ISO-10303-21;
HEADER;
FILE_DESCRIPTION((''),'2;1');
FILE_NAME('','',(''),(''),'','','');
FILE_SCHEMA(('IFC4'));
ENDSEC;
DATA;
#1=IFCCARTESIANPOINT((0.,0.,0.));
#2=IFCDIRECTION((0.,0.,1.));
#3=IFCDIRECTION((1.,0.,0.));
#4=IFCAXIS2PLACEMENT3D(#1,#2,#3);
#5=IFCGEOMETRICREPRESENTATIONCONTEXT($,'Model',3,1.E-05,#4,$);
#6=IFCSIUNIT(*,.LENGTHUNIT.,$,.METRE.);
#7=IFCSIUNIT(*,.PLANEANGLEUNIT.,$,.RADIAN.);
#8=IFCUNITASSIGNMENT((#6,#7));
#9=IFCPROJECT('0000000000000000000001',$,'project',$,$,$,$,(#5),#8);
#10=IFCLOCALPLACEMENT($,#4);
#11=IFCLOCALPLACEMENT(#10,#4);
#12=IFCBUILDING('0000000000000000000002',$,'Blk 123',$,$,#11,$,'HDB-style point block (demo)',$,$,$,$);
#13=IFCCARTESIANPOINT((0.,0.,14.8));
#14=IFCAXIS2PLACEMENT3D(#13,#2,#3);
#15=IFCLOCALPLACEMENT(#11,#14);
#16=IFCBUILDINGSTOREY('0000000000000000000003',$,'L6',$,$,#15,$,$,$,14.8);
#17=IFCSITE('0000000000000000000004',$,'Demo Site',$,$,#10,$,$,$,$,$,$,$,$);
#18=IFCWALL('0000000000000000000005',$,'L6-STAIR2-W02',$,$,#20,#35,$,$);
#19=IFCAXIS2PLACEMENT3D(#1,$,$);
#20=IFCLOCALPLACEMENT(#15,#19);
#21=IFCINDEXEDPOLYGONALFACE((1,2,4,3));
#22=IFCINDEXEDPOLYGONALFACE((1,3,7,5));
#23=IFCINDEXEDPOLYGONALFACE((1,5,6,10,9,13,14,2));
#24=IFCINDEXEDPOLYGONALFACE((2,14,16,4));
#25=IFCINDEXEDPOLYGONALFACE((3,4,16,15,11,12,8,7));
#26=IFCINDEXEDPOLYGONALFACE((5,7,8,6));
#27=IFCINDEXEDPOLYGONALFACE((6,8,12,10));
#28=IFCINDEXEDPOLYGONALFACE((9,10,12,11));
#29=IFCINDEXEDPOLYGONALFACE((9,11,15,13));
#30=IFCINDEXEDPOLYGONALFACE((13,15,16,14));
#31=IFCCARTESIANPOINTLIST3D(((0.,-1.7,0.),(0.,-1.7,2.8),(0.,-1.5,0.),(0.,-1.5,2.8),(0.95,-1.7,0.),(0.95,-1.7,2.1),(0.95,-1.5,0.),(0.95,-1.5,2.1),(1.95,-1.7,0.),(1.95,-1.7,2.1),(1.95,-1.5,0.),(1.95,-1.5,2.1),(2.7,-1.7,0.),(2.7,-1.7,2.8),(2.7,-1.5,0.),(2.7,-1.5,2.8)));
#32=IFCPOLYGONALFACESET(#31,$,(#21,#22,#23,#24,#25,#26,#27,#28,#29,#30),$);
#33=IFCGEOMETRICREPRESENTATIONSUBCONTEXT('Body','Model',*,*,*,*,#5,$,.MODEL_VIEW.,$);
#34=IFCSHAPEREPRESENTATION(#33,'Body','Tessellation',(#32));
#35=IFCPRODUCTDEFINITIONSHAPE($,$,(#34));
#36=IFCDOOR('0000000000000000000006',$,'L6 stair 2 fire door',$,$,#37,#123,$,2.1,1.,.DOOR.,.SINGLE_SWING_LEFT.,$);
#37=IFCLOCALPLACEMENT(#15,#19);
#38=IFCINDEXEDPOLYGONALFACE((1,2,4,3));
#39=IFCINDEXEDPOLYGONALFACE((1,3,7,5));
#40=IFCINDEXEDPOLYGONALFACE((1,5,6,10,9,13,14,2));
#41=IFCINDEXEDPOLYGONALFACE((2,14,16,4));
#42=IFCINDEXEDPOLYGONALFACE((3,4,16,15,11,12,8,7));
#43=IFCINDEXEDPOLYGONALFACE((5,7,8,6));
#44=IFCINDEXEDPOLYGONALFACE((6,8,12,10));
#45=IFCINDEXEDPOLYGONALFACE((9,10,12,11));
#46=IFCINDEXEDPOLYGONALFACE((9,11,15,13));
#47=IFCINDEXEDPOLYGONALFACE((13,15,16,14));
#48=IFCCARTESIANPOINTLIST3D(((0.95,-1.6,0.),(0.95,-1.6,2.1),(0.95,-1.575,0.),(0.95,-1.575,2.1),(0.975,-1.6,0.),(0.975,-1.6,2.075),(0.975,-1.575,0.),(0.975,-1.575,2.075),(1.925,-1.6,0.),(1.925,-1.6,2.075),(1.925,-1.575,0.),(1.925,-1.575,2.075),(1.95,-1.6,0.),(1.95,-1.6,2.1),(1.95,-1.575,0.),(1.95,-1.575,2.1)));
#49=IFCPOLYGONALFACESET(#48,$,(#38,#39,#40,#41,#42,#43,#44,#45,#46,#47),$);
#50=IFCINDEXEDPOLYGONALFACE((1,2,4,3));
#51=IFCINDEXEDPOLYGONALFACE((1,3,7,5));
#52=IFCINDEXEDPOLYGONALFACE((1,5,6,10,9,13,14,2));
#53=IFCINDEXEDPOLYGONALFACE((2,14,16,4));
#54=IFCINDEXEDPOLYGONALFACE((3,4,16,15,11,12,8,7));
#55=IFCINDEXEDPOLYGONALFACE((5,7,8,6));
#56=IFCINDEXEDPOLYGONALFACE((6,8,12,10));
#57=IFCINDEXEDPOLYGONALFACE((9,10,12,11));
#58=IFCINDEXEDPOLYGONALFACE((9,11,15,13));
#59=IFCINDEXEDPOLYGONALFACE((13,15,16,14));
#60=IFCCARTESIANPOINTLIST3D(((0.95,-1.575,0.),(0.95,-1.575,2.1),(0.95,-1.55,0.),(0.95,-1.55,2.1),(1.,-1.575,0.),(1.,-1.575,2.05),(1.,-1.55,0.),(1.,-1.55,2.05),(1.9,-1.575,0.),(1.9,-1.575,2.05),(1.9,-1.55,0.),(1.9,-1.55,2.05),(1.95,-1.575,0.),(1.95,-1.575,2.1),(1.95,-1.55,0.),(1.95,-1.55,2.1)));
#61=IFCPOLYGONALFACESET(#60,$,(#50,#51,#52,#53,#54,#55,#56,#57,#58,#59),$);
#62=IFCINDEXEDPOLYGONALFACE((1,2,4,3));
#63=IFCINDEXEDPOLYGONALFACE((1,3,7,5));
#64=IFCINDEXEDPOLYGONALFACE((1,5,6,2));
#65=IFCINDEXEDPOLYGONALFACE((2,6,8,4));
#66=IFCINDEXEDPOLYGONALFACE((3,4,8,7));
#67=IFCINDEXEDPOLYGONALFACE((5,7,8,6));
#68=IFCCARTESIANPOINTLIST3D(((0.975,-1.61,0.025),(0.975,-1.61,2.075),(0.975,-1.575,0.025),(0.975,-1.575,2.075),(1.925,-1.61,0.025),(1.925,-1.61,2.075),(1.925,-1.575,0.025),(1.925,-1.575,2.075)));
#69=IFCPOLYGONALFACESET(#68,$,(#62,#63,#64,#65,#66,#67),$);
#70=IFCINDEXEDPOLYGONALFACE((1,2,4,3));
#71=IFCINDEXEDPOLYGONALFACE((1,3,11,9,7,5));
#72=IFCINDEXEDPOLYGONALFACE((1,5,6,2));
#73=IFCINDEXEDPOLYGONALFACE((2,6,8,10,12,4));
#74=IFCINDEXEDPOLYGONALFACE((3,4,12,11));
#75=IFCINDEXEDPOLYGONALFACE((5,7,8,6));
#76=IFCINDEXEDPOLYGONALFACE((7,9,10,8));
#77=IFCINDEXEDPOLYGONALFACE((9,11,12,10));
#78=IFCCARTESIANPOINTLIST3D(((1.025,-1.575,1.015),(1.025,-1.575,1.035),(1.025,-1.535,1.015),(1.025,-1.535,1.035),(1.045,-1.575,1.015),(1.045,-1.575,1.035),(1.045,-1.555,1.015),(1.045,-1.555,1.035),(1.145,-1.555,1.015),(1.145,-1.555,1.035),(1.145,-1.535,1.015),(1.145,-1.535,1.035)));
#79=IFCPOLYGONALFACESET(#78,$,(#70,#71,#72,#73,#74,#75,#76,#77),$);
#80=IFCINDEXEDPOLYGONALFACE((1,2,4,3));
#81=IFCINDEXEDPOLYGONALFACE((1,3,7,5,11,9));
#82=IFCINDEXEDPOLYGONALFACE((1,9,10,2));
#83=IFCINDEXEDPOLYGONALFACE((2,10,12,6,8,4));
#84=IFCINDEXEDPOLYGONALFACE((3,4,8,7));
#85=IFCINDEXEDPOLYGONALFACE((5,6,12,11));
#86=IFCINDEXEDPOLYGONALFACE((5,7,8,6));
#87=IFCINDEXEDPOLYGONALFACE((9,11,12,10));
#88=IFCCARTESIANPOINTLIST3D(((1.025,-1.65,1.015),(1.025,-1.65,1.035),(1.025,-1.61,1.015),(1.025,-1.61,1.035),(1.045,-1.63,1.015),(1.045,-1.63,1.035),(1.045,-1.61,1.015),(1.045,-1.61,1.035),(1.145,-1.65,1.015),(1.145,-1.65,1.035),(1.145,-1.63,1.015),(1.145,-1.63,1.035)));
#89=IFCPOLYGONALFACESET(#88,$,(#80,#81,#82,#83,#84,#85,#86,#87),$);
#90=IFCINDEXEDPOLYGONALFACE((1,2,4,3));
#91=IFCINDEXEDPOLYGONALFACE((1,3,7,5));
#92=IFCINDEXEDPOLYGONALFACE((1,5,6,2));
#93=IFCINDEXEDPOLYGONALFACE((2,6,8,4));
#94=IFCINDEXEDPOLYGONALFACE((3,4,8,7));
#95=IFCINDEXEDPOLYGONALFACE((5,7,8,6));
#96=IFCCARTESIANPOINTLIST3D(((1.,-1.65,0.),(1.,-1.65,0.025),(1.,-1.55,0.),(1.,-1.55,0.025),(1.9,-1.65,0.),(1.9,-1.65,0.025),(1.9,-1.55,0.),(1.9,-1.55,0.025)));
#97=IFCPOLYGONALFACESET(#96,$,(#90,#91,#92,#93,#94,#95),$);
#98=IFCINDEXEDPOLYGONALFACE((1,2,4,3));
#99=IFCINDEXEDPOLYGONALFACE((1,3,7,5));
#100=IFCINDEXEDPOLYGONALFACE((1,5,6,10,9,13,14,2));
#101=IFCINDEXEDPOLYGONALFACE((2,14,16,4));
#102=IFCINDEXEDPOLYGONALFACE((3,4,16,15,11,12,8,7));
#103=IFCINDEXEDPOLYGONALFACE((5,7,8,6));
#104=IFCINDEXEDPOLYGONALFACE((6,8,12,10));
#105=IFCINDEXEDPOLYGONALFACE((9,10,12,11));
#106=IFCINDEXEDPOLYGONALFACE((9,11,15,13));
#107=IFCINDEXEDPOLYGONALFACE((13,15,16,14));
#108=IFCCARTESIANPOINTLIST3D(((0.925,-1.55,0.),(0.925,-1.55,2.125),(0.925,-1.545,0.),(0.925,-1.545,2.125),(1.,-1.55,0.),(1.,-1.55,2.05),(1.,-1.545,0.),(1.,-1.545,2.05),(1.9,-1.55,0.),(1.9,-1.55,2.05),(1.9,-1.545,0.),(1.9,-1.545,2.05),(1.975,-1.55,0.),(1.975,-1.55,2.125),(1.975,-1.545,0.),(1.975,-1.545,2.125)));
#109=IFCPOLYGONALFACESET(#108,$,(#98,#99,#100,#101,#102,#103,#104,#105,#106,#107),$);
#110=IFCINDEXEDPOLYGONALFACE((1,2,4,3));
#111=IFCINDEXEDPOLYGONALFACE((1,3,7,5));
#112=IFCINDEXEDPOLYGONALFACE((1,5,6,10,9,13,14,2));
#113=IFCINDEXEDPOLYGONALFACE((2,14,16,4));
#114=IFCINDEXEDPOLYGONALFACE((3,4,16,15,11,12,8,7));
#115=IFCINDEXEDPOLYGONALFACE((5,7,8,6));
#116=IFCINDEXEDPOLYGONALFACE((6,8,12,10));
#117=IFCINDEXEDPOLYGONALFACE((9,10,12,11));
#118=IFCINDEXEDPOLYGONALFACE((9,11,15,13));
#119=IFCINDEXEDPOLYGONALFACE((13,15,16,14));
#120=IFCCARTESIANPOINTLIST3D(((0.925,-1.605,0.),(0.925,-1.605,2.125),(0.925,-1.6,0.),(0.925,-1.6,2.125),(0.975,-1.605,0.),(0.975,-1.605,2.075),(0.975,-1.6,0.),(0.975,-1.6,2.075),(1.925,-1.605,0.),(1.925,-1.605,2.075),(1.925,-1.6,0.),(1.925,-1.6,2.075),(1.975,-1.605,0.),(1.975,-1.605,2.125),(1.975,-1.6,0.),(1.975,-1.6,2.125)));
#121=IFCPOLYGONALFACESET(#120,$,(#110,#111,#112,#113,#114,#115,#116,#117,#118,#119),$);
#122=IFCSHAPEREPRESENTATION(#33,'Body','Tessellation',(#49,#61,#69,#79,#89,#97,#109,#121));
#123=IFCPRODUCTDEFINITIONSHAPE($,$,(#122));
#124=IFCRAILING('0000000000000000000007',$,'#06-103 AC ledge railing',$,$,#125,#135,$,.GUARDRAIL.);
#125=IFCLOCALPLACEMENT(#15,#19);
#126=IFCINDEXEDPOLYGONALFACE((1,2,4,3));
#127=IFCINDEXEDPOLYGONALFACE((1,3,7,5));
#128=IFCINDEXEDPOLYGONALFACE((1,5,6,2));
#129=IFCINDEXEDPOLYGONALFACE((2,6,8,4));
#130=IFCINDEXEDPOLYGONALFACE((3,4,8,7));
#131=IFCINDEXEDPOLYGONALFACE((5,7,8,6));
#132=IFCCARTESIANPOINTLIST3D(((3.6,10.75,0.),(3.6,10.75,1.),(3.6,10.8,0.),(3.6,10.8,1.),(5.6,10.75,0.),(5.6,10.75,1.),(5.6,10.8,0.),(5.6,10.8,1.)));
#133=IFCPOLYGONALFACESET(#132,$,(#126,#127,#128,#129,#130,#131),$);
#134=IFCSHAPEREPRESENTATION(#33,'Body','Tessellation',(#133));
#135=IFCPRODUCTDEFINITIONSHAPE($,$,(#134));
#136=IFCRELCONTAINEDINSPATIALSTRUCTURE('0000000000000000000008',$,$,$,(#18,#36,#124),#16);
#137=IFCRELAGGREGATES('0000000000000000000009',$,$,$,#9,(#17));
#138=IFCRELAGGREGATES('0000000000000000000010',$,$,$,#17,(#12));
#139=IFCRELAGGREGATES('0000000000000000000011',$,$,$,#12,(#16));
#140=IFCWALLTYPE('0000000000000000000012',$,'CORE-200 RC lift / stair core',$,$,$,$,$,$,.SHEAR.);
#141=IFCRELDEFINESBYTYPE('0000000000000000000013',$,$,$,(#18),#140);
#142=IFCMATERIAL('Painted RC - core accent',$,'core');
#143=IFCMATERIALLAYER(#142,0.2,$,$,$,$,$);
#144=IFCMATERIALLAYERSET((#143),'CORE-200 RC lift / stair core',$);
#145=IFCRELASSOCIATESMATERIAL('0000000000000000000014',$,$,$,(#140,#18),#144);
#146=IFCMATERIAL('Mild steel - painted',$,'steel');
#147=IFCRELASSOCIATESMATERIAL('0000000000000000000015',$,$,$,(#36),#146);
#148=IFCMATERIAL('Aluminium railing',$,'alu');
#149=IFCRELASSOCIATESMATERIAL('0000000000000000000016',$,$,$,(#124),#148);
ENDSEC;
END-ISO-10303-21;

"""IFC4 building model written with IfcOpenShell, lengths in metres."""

from ifc_helpers import new_model, si_unit, frame, origin, origin_with_axes, place, context, subcontext, project, spatial, polyline, line, indexed_curve, outline, extrude, material, layer, layer_set, layer_usage, type_object, element, fill, save


model = new_model("IFC4")

# Units and contexts
model_context = context("Model", 3, precision=1e-05, world=origin_with_axes())
body_context = subcontext(model_context, "Body", "Model", "MODEL_VIEW")
ifc_project = project(units=[si_unit("LENGTHUNIT", "METRE"), si_unit("PLANEANGLEUNIT", "RADIAN")], contexts=[model_context])

# Site, building, storey
site_placement = place(None, origin_with_axes())
site = spatial("IfcSite", under=ifc_project, at=site_placement, Name="Demo Site")
building_placement = place(site_placement, origin_with_axes())
building = spatial("IfcBuilding", under=site, at=building_placement, Name="Blk 123", LongName="HDB-style point block (demo)")
storey_placement = place(building_placement, frame((0.0, 0.0, 14.8), z_axis=(0.0, 0.0, 1.0), x_axis=(1.0, 0.0, 0.0)))
storey = spatial("IfcBuildingStorey", under=building, at=storey_placement, Name="L6", Elevation=14.8)

# Shared definitions
ifc_material_1 = material(Name="Painted RC - core accent", Category="core")
ifc_layer_1 = layer(ifc_material_1, 0.2)
ifc_layer_set_1 = layer_set([ifc_layer_1], Name="CORE-200 RC lift / stair core")
ifc_layer_usage_1 = layer_usage(ifc_layer_set_1, "AXIS2", "POSITIVE", 0.0)
wall_type_1 = type_object("IfcWallType", Name="CORE-200 RC lift / stair core", PredefinedType="SHEAR", material=ifc_layer_set_1)

# Wall, opening, door
wall_1_placement = place(storey_placement, frame((2.7, -1.5, 0.0), z_axis=(0.0, 0.0, 1.0), x_axis=(-1.0, 0.0, 0.0)))
wall_1 = element("IfcWall", 1, at=wall_1_placement, inside=storey, type_object=wall_type_1, material=ifc_layer_usage_1, Name="L6-STAIR2-W02", context=body_context, shape_type="SweptSolid", body=[
    extrude(outline(indexed_curve([(0.0, 0.0), (0.0, 0.2), (2.7, 0.2), (2.7, 0.0), (0.0, 0.0)], self_intersect=False)), origin_with_axes(), (0.0, 0.0, 1.0), 2.8),
])
opening_1_placement = place(wall_1_placement, frame((0.75, -0.1, 0.0), z_axis=(0.0, 0.0, 1.0), x_axis=(1.0, 0.0, 0.0)))
opening_1 = element("IfcOpeningElement", 2, at=opening_1_placement, cuts=wall_1, context=body_context, shape_type="SweptSolid", body=[
    extrude(outline(indexed_curve([(0.0, 0.0), (0.0, 0.4), (1.0, 0.4), (1.0, 0.0), (0.0, 0.0)], self_intersect=False)), origin_with_axes(), (0.0, 0.0, 1.0), 2.1),
])
ifc_material_2 = material(Name="Mild steel - painted", Category="steel")
door_1_placement = place(opening_1_placement, frame((0.0, 0.15, 0.0), z_axis=(0.0, 0.0, 1.0), x_axis=(1.0, 0.0, 0.0)))
door_1 = element("IfcDoor", 3, at=door_1_placement, inside=storey, material=ifc_material_2, Name="L6 stair 2 fire door", OperationType="SINGLE_SWING_LEFT", OverallHeight=2.1, OverallWidth=1.0, PredefinedType="DOOR", context=body_context, shape_type="SweptSolid", body=[
    extrude(outline(indexed_curve([(0.0, 0.0), (0.0, 2.1), (1.0, 2.1), (1.0, 0.0), (0.975, 0.0), (0.975, 2.075), (0.025, 2.075), (0.025, 0.0)], segments=[line(1, 2, 3, 4, 5, 6, 7, 8, 1)])), frame((0.0, 0.025, 0.0), z_axis=(0.0, -1.0, 0.0), x_axis=(1.0, 0.0, 0.0)), (0.0, 0.0, -1.0), 0.025),
    extrude(outline(indexed_curve([(0.0, 0.0), (0.0, 2.1), (1.0, 2.1), (1.0, 0.0), (0.95, 0.0), (0.95, 2.05), (0.05, 2.05), (0.05, 0.0)], segments=[line(1, 2, 3, 4, 5, 6, 7, 8, 1)])), frame((0.0, 0.0, 0.0), z_axis=(0.0, -1.0, 0.0), x_axis=(1.0, 0.0, 0.0)), (0.0, 0.0, -1.0), 0.025),
    extrude(outline(indexed_curve([(0.0, 0.0), (0.95, 0.0), (0.95, 0.035), (0.0, 0.035)], segments=[line(1, 2, 3, 4, 1)])), frame((0.025, 0.025, 0.025), z_axis=(0.0, 0.0, 1.0), x_axis=(1.0, 0.0, 0.0)), (0.0, 0.0, 1.0), 2.05),
    extrude(outline(indexed_curve([(0.0, 0.0), (0.0, -0.04), (-0.12, -0.04), (-0.12, -0.02), (-0.02, -0.02), (-0.02, 0.0)], segments=[line(1, 2, 3, 4, 5, 6, 1)])), frame((0.925, 0.025, 1.015), z_axis=(0.0, 0.0, 1.0), x_axis=(1.0, 0.0, 0.0)), (0.0, 0.0, 1.0), 0.02),
    extrude(outline(indexed_curve([(0.0, 0.0), (0.0, 0.04), (-0.12, 0.04), (-0.12, 0.02), (-0.02, 0.02), (-0.02, 0.0)], segments=[line(1, 2, 3, 4, 5, 6, 1)])), frame((0.925, 0.06, 1.015), z_axis=(0.0, 0.0, 1.0), x_axis=(1.0, 0.0, 0.0)), (0.0, 0.0, 1.0), 0.02),
    extrude(outline(indexed_curve([(0.0, 0.0), (0.9, 0.0), (0.9, 0.1), (0.0, 0.1)], segments=[line(1, 2, 3, 4, 1)])), frame((0.05, 0.0, 0.0), z_axis=(0.0, 0.0, 1.0), x_axis=(1.0, 0.0, 0.0)), (0.0, 0.0, 1.0), 0.025),
    extrude(outline(indexed_curve([(0.0, 0.0), (0.0, 2.125), (1.05, 2.125), (1.05, 0.0), (0.975, 0.0), (0.975, 2.05), (0.075, 2.05), (0.075, 0.0)], segments=[line(1, 2, 3, 4, 5, 6, 7, 8, 1)])), frame((-0.025, -0.005, 0.0), z_axis=(0.0, -1.0, 0.0), x_axis=(1.0, 0.0, 0.0)), (0.0, 0.0, -1.0), 0.005),
    extrude(outline(indexed_curve([(0.0, 0.0), (0.0, 2.125), (1.05, 2.125), (1.05, 0.0), (1.0, 0.0), (1.0, 2.075), (0.05, 2.075), (0.05, 0.0)], segments=[line(1, 2, 3, 4, 5, 6, 7, 8, 1)])), frame((-0.025, 0.05, 0.0), z_axis=(0.0, -1.0, 0.0), x_axis=(1.0, 0.0, 0.0)), (0.0, 0.0, -1.0), 0.005),
])
fill(opening_1, door_1)

# Railing
ifc_material_3 = material(Name="Aluminium railing", Category="alu")
railing_placement = place(storey_placement, frame((4.6, 10.775, 0.0), z_axis=(0.0, 0.0, 1.0), x_axis=(1.0, 0.0, 0.0)))
element("IfcRailing", 4, at=railing_placement, inside=storey, material=ifc_material_3, Name="#06-103 AC ledge railing", PredefinedType="GUARDRAIL", context=body_context, shape_type="SweptSolid", body=[
    extrude(outline(polyline([(1.0, -0.025), (1.0, 0.025), (-1.0, 0.025), (-1.0, -0.025), (1.0, -0.025)])), origin(), (0.0, 0.0, 1.0), 1.0),
])

save(model, "model.ifc")
